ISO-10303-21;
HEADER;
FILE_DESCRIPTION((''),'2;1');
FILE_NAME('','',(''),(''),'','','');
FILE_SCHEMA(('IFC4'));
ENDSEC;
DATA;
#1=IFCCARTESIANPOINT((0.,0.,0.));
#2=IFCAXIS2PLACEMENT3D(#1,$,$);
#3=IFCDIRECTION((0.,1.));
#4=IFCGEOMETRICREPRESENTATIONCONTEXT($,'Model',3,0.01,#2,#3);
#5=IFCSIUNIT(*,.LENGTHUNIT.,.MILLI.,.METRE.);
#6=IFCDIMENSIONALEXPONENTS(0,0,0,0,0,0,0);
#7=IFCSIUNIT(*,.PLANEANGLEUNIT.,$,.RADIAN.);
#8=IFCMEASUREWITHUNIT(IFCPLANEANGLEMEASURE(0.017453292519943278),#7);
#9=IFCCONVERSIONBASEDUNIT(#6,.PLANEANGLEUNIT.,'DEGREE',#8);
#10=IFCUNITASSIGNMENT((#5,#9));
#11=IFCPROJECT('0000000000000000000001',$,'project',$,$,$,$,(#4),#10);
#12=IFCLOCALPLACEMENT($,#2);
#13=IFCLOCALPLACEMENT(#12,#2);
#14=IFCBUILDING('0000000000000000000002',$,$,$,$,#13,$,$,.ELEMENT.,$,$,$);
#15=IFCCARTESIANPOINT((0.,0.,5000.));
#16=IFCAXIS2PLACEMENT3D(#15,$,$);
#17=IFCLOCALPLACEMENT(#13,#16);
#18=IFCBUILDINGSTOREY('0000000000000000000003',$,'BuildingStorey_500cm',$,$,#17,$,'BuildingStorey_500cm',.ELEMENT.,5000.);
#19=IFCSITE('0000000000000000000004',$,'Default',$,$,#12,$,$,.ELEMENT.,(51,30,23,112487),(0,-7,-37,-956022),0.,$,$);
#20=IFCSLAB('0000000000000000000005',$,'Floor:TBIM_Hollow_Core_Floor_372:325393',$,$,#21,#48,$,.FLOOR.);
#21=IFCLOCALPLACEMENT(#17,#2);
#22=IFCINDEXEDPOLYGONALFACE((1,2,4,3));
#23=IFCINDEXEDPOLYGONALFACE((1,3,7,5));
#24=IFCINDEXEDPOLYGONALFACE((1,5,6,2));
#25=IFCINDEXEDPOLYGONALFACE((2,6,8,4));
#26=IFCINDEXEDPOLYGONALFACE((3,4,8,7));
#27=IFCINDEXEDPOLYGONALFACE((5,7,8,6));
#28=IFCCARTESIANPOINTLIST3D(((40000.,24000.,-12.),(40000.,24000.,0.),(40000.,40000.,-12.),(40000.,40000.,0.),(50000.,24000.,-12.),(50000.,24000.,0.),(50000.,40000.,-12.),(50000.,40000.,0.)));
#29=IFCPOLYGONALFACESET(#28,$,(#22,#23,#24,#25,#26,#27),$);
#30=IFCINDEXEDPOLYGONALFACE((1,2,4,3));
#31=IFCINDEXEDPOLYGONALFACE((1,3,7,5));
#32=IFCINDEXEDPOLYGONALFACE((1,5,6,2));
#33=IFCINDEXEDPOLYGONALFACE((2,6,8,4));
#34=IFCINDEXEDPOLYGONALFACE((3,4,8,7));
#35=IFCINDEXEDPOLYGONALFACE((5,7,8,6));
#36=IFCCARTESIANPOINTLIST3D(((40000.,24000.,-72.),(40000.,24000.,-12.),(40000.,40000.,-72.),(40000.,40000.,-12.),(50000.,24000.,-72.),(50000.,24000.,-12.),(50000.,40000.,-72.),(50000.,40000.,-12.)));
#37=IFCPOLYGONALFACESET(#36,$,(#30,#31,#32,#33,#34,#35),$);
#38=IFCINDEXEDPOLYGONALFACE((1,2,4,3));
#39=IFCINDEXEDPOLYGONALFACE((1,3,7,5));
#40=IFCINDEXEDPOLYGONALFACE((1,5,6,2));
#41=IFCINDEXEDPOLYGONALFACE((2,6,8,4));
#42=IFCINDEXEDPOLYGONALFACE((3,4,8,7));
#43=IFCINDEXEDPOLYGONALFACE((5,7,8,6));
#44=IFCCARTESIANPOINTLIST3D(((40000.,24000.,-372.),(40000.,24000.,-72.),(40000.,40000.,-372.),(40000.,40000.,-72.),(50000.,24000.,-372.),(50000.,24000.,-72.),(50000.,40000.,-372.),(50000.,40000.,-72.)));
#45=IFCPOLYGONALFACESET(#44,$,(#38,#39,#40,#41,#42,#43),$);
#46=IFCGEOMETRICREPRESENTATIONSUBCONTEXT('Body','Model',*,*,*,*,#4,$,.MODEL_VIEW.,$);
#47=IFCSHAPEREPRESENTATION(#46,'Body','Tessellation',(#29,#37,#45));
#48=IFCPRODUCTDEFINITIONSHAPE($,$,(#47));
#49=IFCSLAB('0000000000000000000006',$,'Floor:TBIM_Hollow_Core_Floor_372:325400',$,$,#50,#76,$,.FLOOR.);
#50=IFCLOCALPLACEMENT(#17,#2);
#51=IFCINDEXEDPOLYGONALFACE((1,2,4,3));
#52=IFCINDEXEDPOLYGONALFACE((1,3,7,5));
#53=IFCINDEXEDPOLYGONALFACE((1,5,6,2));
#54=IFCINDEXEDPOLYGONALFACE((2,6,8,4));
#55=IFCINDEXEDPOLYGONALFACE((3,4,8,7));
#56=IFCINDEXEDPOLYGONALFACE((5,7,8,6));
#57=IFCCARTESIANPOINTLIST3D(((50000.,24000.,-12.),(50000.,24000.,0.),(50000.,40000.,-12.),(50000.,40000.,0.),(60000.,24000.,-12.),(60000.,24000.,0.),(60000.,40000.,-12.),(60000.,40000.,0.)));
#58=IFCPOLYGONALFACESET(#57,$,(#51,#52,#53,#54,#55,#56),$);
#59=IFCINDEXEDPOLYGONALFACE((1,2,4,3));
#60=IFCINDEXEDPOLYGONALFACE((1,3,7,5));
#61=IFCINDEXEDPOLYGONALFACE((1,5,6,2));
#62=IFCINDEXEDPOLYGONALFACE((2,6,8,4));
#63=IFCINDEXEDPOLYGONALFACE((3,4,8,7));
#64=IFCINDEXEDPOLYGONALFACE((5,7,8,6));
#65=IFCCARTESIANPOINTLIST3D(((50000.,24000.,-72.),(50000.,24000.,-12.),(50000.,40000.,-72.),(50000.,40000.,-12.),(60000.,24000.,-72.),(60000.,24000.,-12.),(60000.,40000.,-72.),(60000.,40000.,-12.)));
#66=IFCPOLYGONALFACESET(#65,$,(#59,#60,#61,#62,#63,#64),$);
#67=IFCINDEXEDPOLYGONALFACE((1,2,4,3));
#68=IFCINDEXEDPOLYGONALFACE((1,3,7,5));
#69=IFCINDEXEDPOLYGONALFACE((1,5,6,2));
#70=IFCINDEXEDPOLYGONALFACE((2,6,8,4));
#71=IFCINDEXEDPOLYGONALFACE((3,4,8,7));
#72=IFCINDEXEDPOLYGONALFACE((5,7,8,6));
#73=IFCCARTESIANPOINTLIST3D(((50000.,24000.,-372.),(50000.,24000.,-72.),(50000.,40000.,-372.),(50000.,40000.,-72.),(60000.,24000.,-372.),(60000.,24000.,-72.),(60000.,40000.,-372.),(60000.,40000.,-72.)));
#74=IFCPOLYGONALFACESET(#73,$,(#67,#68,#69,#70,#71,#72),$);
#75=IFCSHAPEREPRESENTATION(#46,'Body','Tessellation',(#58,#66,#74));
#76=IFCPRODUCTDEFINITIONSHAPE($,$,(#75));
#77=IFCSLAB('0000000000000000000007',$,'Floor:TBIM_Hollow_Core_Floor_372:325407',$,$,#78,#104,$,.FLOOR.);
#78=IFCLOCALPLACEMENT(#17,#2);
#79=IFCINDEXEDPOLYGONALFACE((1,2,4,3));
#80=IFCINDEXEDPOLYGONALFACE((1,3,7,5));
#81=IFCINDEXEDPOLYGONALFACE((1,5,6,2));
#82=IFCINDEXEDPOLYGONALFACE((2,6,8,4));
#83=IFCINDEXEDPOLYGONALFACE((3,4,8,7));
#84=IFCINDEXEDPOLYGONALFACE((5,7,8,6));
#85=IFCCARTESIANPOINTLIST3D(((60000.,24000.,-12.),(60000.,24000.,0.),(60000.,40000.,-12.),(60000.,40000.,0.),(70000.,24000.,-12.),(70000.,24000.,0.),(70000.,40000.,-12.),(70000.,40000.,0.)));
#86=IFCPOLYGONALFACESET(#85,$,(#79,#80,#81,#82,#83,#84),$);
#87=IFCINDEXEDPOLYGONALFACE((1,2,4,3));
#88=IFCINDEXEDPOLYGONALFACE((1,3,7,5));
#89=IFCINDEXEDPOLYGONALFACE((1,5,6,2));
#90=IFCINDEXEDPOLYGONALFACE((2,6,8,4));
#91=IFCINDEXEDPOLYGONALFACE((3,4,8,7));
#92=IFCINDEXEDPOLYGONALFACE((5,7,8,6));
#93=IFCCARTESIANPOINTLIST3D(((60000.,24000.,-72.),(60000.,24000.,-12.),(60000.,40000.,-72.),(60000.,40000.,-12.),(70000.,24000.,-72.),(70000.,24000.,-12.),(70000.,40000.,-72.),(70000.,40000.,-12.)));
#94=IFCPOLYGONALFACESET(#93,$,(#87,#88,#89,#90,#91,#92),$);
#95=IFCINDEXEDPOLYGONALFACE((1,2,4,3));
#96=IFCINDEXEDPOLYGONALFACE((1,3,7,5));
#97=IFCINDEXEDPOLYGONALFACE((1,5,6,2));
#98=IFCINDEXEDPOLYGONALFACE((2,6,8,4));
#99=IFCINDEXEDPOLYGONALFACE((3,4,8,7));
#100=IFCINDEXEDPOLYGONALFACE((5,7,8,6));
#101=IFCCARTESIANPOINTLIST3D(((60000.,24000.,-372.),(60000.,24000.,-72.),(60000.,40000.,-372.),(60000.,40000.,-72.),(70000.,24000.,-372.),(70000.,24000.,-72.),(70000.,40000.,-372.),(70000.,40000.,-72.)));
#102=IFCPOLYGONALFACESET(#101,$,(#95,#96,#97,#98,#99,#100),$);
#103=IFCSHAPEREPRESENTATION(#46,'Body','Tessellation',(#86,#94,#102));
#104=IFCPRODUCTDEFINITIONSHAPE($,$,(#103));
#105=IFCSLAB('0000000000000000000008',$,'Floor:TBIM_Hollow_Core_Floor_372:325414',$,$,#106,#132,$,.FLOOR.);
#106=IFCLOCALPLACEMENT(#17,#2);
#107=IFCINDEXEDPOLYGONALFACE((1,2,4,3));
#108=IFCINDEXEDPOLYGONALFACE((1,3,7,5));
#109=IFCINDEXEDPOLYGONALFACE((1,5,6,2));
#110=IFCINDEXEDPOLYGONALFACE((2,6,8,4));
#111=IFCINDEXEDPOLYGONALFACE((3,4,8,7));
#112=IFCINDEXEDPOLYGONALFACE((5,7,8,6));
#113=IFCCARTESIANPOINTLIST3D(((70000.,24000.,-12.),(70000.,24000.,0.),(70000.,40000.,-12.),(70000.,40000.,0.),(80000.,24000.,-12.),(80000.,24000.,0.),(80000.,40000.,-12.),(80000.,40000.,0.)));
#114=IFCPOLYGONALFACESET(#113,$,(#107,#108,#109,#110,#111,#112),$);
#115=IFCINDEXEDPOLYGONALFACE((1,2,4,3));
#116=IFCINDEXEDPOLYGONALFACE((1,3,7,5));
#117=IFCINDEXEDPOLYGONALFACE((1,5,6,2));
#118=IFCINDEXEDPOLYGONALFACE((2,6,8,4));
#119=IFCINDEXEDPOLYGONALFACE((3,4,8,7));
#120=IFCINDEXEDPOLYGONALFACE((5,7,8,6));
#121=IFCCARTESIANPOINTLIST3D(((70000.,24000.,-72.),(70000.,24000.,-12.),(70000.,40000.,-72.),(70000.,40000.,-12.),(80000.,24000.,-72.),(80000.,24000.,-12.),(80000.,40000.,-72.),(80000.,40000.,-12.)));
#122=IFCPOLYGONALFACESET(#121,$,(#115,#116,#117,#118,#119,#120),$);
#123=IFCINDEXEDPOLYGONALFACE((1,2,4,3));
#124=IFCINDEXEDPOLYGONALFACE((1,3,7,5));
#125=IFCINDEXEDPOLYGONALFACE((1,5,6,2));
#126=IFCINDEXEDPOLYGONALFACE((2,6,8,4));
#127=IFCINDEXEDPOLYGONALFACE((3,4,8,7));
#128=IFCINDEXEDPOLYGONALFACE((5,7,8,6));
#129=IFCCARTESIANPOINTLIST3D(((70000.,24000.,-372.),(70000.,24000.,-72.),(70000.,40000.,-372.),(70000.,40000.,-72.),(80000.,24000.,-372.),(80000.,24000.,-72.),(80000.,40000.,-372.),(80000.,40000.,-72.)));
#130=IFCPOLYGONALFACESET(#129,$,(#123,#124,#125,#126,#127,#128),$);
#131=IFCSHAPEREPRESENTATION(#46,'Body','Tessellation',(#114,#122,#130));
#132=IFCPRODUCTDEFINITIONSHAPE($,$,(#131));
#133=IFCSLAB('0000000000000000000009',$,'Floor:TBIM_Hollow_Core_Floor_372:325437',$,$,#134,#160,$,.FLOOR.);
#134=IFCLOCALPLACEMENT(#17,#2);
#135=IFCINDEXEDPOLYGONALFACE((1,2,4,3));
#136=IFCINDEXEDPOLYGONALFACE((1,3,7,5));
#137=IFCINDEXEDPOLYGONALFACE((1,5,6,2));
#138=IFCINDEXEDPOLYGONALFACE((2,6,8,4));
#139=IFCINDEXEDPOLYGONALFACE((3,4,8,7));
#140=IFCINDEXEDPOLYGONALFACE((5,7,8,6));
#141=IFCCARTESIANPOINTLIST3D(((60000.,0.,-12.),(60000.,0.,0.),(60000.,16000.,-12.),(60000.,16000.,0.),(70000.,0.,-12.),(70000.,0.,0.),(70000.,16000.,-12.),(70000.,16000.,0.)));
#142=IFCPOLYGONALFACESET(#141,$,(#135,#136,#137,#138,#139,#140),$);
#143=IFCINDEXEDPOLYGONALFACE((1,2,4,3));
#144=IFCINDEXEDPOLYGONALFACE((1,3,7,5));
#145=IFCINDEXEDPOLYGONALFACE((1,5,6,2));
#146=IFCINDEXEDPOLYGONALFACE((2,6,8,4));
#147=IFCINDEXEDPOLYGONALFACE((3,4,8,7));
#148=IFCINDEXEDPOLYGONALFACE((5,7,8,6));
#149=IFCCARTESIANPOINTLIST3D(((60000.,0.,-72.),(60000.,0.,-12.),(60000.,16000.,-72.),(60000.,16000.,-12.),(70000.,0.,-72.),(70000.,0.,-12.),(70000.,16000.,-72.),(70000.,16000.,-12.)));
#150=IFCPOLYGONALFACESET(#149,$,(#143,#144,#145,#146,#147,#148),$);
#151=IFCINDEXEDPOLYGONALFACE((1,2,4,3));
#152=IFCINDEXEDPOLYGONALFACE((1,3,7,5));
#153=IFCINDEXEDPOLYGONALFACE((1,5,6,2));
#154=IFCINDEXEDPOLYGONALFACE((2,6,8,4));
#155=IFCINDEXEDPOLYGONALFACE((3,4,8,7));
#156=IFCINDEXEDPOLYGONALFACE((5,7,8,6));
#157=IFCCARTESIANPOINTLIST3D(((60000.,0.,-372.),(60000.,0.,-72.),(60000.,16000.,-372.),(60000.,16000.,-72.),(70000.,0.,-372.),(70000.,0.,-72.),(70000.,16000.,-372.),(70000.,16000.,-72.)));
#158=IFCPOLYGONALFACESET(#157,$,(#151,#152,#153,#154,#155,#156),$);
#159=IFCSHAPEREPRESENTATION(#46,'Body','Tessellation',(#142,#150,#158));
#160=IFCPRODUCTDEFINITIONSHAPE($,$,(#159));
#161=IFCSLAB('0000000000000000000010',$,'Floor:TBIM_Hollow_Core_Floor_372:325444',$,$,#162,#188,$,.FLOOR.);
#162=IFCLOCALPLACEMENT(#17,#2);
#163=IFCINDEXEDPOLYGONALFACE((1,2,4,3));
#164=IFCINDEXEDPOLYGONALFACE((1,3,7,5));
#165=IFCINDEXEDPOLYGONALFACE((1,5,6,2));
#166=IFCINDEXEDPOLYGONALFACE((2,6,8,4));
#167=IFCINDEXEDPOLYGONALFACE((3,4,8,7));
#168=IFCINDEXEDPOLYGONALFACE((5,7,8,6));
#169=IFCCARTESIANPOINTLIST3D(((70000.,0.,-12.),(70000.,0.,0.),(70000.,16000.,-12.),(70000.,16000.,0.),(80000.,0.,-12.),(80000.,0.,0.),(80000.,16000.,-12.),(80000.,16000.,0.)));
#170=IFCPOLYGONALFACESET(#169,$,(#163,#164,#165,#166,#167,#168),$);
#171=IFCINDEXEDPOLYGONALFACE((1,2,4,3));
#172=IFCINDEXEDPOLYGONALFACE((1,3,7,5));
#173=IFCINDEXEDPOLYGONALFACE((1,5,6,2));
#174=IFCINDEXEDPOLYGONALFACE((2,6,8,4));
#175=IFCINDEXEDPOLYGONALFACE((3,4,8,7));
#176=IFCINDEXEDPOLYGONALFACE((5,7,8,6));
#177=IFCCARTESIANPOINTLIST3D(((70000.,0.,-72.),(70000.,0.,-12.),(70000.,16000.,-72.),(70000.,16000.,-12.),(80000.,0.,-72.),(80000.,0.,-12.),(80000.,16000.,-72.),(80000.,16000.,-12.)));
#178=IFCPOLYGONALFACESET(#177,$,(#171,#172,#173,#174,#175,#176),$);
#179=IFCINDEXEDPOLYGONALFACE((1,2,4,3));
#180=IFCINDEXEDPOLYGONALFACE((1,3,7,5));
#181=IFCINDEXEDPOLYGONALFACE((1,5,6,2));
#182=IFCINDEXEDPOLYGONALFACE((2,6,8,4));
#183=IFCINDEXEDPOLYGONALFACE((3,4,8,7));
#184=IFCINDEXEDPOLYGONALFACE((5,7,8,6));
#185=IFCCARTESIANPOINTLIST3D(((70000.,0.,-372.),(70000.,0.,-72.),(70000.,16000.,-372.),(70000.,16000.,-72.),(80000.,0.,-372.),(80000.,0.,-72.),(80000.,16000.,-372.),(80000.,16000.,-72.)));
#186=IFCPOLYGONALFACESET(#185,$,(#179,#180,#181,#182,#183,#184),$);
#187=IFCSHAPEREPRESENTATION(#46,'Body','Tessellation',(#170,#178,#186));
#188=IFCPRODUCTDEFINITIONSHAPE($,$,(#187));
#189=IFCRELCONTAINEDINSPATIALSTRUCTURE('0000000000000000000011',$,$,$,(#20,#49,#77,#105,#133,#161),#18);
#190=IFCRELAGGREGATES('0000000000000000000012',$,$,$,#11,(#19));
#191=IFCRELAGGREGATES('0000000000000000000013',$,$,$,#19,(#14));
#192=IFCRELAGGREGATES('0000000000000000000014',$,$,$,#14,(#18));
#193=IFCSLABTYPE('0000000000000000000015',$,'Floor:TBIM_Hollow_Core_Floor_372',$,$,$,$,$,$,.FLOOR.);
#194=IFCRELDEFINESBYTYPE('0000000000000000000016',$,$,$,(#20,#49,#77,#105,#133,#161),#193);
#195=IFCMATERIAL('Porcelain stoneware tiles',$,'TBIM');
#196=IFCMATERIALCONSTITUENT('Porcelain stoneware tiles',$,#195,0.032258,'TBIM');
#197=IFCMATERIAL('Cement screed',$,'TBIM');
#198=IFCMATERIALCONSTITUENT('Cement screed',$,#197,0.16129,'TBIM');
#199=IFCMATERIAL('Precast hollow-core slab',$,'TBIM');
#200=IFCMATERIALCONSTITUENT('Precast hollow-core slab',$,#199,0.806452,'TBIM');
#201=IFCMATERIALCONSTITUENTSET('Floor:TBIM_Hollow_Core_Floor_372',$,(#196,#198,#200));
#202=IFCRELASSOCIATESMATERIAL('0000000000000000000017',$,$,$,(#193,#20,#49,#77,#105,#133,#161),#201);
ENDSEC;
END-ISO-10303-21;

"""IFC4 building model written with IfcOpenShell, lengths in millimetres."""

from ifc_helpers import new_model, entity, si_unit, converted_unit, direction, frame, origin, place, context, subcontext, project, spatial, indexed_curve, outline, extrude, material, constituent, constituent_set, type_object, element, save


model = new_model("IFC4")

# Units and contexts
model_context = context("Model", 3, precision=0.01, world=origin(), true_north=direction((0.0, 1.0)))
body_context = subcontext(model_context, "Body", "Model", "MODEL_VIEW")
ifc_project = project(units=[si_unit("LENGTHUNIT", "METRE", prefix="MILLI"), converted_unit("PLANEANGLEUNIT", "DEGREE", entity("IfcPlaneAngleMeasure", 0.017453292519943278), si_unit("PLANEANGLEUNIT", "RADIAN"), dimensions=[0, 0, 0, 0, 0, 0, 0])], contexts=[model_context])

# Site, building, storey
site_placement = place(None, origin())
site = spatial("IfcSite", under=ifc_project, at=site_placement, Name="Default", CompositionType="ELEMENT", RefLatitude=(51, 30, 23, 112487), RefLongitude=(0, -7, -37, -956022), RefElevation=0.0)
building_placement = place(site_placement, origin())
building = spatial("IfcBuilding", under=site, at=building_placement, CompositionType="ELEMENT")
storey_placement = place(building_placement, frame((0.0, 0.0, 5000.0)))
storey = spatial("IfcBuildingStorey", under=building, at=storey_placement, Name="BuildingStorey_500cm", LongName="BuildingStorey_500cm", CompositionType="ELEMENT", Elevation=5000.0)

# Slabs
ifc_material_1 = material(Name="Porcelain stoneware tiles", Category="TBIM")
ifc_constituent_1 = constituent(ifc_material_1, Name="Porcelain stoneware tiles", Category="TBIM", fraction=0.032258)
ifc_material_2 = material(Name="Cement screed", Category="TBIM")
ifc_constituent_2 = constituent(ifc_material_2, Name="Cement screed", Category="TBIM", fraction=0.16129)
ifc_material_3 = material(Name="Precast hollow-core slab", Category="TBIM")
ifc_constituent_3 = constituent(ifc_material_3, Name="Precast hollow-core slab", Category="TBIM", fraction=0.806452)
ifc_constituent_set_1 = constituent_set(constituents=[ifc_constituent_1, ifc_constituent_2, ifc_constituent_3], Name="Floor:TBIM_Hollow_Core_Floor_372")
slab_type = type_object("IfcSlabType", Name="Floor:TBIM_Hollow_Core_Floor_372", PredefinedType="FLOOR", material=ifc_constituent_set_1)
slab_1_placement = place(storey_placement, origin())
element("IfcSlab", 1, at=slab_1_placement, inside=storey, type_object=slab_type, material=ifc_constituent_set_1, Name="Floor:TBIM_Hollow_Core_Floor_372:325393", PredefinedType="FLOOR", context=body_context, shape_type="SweptSolid", body=[
    extrude(outline(indexed_curve([(-5000.0, -8000.0), (5000.0, -8000.0), (5000.0, 8000.0), (-5000.0, 8000.0), (-5000.0, -8000.0)], self_intersect=False)), frame((45000.0, 32000.0, -12.0), z_axis=(0.0, 0.0, 1.0), x_axis=(-1.0, 0.0, 0.0)), (0.0, 0.0, 1.0), 12.0),
    extrude(outline(indexed_curve([(-5000.0, -8000.0), (5000.0, -8000.0), (5000.0, 8000.0), (-5000.0, 8000.0), (-5000.0, -8000.0)], self_intersect=False)), frame((45000.0, 32000.0, -72.0), z_axis=(0.0, 0.0, 1.0), x_axis=(-1.0, 0.0, 0.0)), (0.0, 0.0, 1.0), 60.0),
    extrude(outline(indexed_curve([(-5000.0, -8000.0), (5000.0, -8000.0), (5000.0, 8000.0), (-5000.0, 8000.0), (-5000.0, -8000.0)], self_intersect=False)), frame((45000.0, 32000.0, -372.0), z_axis=(0.0, 0.0, 1.0), x_axis=(-1.0, 0.0, 0.0)), (0.0, 0.0, 1.0), 300.0),
])
slab_2_placement = place(storey_placement, origin())
element("IfcSlab", 2, at=slab_2_placement, inside=storey, type_object=slab_type, material=ifc_constituent_set_1, Name="Floor:TBIM_Hollow_Core_Floor_372:325400", PredefinedType="FLOOR", context=body_context, shape_type="SweptSolid", body=[
    extrude(outline(indexed_curve([(-5000.0, -8000.0), (5000.0, -8000.0), (5000.0, 8000.0), (-5000.0, 8000.0), (-5000.0, -8000.0)], self_intersect=False)), frame((55000.0, 32000.0, -12.0), z_axis=(0.0, 0.0, 1.0), x_axis=(-1.0, 0.0, 0.0)), (0.0, 0.0, 1.0), 12.0),
    extrude(outline(indexed_curve([(-5000.0, -8000.0), (5000.0, -8000.0), (5000.0, 8000.0), (-5000.0, 8000.0), (-5000.0, -8000.0)], self_intersect=False)), frame((55000.0, 32000.0, -72.0), z_axis=(0.0, 0.0, 1.0), x_axis=(-1.0, 0.0, 0.0)), (0.0, 0.0, 1.0), 60.0),
    extrude(outline(indexed_curve([(-5000.0, -8000.0), (5000.0, -8000.0), (5000.0, 8000.0), (-5000.0, 8000.0), (-5000.0, -8000.0)], self_intersect=False)), frame((55000.0, 32000.0, -372.0), z_axis=(0.0, 0.0, 1.0), x_axis=(-1.0, 0.0, 0.0)), (0.0, 0.0, 1.0), 300.0),
])
slab_3_placement = place(storey_placement, origin())
element("IfcSlab", 3, at=slab_3_placement, inside=storey, type_object=slab_type, material=ifc_constituent_set_1, Name="Floor:TBIM_Hollow_Core_Floor_372:325407", PredefinedType="FLOOR", context=body_context, shape_type="SweptSolid", body=[
    extrude(outline(indexed_curve([(-5000.0, -8000.0), (5000.0, -8000.0), (5000.0, 8000.0), (-5000.0, 8000.0), (-5000.0, -8000.0)], self_intersect=False)), frame((65000.0, 32000.0, -12.0), z_axis=(0.0, 0.0, 1.0), x_axis=(-1.0, 0.0, 0.0)), (0.0, 0.0, 1.0), 12.0),
    extrude(outline(indexed_curve([(-5000.0, -8000.0), (5000.0, -8000.0), (5000.0, 8000.0), (-5000.0, 8000.0), (-5000.0, -8000.0)], self_intersect=False)), frame((65000.0, 32000.0, -72.0), z_axis=(0.0, 0.0, 1.0), x_axis=(-1.0, 0.0, 0.0)), (0.0, 0.0, 1.0), 60.0),
    extrude(outline(indexed_curve([(-5000.0, -8000.0), (5000.0, -8000.0), (5000.0, 8000.0), (-5000.0, 8000.0), (-5000.0, -8000.0)], self_intersect=False)), frame((65000.0, 32000.0, -372.0), z_axis=(0.0, 0.0, 1.0), x_axis=(-1.0, 0.0, 0.0)), (0.0, 0.0, 1.0), 300.0),
])
slab_4_placement = place(storey_placement, origin())
element("IfcSlab", 4, at=slab_4_placement, inside=storey, type_object=slab_type, material=ifc_constituent_set_1, Name="Floor:TBIM_Hollow_Core_Floor_372:325414", PredefinedType="FLOOR", context=body_context, shape_type="SweptSolid", body=[
    extrude(outline(indexed_curve([(-5000.0, -8000.0), (5000.0, -8000.0), (5000.0, 8000.0), (-5000.0, 8000.0), (-5000.0, -8000.0)], self_intersect=False)), frame((75000.0, 32000.0, -12.0), z_axis=(0.0, 0.0, 1.0), x_axis=(-1.0, 0.0, 0.0)), (0.0, 0.0, 1.0), 12.0),
    extrude(outline(indexed_curve([(-5000.0, -8000.0), (5000.0, -8000.0), (5000.0, 8000.0), (-5000.0, 8000.0), (-5000.0, -8000.0)], self_intersect=False)), frame((75000.0, 32000.0, -72.0), z_axis=(0.0, 0.0, 1.0), x_axis=(-1.0, 0.0, 0.0)), (0.0, 0.0, 1.0), 60.0),
    extrude(outline(indexed_curve([(-5000.0, -8000.0), (5000.0, -8000.0), (5000.0, 8000.0), (-5000.0, 8000.0), (-5000.0, -8000.0)], self_intersect=False)), frame((75000.0, 32000.0, -372.0), z_axis=(0.0, 0.0, 1.0), x_axis=(-1.0, 0.0, 0.0)), (0.0, 0.0, 1.0), 300.0),
])
slab_5_placement = place(storey_placement, origin())
element("IfcSlab", 5, at=slab_5_placement, inside=storey, type_object=slab_type, material=ifc_constituent_set_1, Name="Floor:TBIM_Hollow_Core_Floor_372:325437", PredefinedType="FLOOR", context=body_context, shape_type="SweptSolid", body=[
    extrude(outline(indexed_curve([(-5000.0, -8000.0), (5000.0, -8000.0), (5000.0, 8000.0), (-5000.0, 8000.0), (-5000.0, -8000.0)], self_intersect=False)), frame((65000.0, 8000.0, -12.0), z_axis=(0.0, 0.0, 1.0), x_axis=(-1.0, 0.0, 0.0)), (0.0, 0.0, 1.0), 12.0),
    extrude(outline(indexed_curve([(-5000.0, -8000.0), (5000.0, -8000.0), (5000.0, 8000.0), (-5000.0, 8000.0), (-5000.0, -8000.0)], self_intersect=False)), frame((65000.0, 8000.0, -72.0), z_axis=(0.0, 0.0, 1.0), x_axis=(-1.0, 0.0, 0.0)), (0.0, 0.0, 1.0), 60.0),
    extrude(outline(indexed_curve([(-5000.0, -8000.0), (5000.0, -8000.0), (5000.0, 8000.0), (-5000.0, 8000.0), (-5000.0, -8000.0)], self_intersect=False)), frame((65000.0, 8000.0, -372.0), z_axis=(0.0, 0.0, 1.0), x_axis=(-1.0, 0.0, 0.0)), (0.0, 0.0, 1.0), 300.0),
])
slab_6_placement = place(storey_placement, origin())
element("IfcSlab", 6, at=slab_6_placement, inside=storey, type_object=slab_type, material=ifc_constituent_set_1, Name="Floor:TBIM_Hollow_Core_Floor_372:325444", PredefinedType="FLOOR", context=body_context, shape_type="SweptSolid", body=[
    extrude(outline(indexed_curve([(-5000.0, -8000.0), (5000.0, -8000.0), (5000.0, 8000.0), (-5000.0, 8000.0), (-5000.0, -8000.0)], self_intersect=False)), frame((75000.0, 8000.0, -12.0), z_axis=(0.0, 0.0, 1.0), x_axis=(-1.0, 0.0, 0.0)), (0.0, 0.0, 1.0), 12.0),
    extrude(outline(indexed_curve([(-5000.0, -8000.0), (5000.0, -8000.0), (5000.0, 8000.0), (-5000.0, 8000.0), (-5000.0, -8000.0)], self_intersect=False)), frame((75000.0, 8000.0, -72.0), z_axis=(0.0, 0.0, 1.0), x_axis=(-1.0, 0.0, 0.0)), (0.0, 0.0, 1.0), 60.0),
    extrude(outline(indexed_curve([(-5000.0, -8000.0), (5000.0, -8000.0), (5000.0, 8000.0), (-5000.0, 8000.0), (-5000.0, -8000.0)], self_intersect=False)), frame((75000.0, 8000.0, -372.0), z_axis=(0.0, 0.0, 1.0), x_axis=(-1.0, 0.0, 0.0)), (0.0, 0.0, 1.0), 300.0),
])

save(model, "model.ifc")
